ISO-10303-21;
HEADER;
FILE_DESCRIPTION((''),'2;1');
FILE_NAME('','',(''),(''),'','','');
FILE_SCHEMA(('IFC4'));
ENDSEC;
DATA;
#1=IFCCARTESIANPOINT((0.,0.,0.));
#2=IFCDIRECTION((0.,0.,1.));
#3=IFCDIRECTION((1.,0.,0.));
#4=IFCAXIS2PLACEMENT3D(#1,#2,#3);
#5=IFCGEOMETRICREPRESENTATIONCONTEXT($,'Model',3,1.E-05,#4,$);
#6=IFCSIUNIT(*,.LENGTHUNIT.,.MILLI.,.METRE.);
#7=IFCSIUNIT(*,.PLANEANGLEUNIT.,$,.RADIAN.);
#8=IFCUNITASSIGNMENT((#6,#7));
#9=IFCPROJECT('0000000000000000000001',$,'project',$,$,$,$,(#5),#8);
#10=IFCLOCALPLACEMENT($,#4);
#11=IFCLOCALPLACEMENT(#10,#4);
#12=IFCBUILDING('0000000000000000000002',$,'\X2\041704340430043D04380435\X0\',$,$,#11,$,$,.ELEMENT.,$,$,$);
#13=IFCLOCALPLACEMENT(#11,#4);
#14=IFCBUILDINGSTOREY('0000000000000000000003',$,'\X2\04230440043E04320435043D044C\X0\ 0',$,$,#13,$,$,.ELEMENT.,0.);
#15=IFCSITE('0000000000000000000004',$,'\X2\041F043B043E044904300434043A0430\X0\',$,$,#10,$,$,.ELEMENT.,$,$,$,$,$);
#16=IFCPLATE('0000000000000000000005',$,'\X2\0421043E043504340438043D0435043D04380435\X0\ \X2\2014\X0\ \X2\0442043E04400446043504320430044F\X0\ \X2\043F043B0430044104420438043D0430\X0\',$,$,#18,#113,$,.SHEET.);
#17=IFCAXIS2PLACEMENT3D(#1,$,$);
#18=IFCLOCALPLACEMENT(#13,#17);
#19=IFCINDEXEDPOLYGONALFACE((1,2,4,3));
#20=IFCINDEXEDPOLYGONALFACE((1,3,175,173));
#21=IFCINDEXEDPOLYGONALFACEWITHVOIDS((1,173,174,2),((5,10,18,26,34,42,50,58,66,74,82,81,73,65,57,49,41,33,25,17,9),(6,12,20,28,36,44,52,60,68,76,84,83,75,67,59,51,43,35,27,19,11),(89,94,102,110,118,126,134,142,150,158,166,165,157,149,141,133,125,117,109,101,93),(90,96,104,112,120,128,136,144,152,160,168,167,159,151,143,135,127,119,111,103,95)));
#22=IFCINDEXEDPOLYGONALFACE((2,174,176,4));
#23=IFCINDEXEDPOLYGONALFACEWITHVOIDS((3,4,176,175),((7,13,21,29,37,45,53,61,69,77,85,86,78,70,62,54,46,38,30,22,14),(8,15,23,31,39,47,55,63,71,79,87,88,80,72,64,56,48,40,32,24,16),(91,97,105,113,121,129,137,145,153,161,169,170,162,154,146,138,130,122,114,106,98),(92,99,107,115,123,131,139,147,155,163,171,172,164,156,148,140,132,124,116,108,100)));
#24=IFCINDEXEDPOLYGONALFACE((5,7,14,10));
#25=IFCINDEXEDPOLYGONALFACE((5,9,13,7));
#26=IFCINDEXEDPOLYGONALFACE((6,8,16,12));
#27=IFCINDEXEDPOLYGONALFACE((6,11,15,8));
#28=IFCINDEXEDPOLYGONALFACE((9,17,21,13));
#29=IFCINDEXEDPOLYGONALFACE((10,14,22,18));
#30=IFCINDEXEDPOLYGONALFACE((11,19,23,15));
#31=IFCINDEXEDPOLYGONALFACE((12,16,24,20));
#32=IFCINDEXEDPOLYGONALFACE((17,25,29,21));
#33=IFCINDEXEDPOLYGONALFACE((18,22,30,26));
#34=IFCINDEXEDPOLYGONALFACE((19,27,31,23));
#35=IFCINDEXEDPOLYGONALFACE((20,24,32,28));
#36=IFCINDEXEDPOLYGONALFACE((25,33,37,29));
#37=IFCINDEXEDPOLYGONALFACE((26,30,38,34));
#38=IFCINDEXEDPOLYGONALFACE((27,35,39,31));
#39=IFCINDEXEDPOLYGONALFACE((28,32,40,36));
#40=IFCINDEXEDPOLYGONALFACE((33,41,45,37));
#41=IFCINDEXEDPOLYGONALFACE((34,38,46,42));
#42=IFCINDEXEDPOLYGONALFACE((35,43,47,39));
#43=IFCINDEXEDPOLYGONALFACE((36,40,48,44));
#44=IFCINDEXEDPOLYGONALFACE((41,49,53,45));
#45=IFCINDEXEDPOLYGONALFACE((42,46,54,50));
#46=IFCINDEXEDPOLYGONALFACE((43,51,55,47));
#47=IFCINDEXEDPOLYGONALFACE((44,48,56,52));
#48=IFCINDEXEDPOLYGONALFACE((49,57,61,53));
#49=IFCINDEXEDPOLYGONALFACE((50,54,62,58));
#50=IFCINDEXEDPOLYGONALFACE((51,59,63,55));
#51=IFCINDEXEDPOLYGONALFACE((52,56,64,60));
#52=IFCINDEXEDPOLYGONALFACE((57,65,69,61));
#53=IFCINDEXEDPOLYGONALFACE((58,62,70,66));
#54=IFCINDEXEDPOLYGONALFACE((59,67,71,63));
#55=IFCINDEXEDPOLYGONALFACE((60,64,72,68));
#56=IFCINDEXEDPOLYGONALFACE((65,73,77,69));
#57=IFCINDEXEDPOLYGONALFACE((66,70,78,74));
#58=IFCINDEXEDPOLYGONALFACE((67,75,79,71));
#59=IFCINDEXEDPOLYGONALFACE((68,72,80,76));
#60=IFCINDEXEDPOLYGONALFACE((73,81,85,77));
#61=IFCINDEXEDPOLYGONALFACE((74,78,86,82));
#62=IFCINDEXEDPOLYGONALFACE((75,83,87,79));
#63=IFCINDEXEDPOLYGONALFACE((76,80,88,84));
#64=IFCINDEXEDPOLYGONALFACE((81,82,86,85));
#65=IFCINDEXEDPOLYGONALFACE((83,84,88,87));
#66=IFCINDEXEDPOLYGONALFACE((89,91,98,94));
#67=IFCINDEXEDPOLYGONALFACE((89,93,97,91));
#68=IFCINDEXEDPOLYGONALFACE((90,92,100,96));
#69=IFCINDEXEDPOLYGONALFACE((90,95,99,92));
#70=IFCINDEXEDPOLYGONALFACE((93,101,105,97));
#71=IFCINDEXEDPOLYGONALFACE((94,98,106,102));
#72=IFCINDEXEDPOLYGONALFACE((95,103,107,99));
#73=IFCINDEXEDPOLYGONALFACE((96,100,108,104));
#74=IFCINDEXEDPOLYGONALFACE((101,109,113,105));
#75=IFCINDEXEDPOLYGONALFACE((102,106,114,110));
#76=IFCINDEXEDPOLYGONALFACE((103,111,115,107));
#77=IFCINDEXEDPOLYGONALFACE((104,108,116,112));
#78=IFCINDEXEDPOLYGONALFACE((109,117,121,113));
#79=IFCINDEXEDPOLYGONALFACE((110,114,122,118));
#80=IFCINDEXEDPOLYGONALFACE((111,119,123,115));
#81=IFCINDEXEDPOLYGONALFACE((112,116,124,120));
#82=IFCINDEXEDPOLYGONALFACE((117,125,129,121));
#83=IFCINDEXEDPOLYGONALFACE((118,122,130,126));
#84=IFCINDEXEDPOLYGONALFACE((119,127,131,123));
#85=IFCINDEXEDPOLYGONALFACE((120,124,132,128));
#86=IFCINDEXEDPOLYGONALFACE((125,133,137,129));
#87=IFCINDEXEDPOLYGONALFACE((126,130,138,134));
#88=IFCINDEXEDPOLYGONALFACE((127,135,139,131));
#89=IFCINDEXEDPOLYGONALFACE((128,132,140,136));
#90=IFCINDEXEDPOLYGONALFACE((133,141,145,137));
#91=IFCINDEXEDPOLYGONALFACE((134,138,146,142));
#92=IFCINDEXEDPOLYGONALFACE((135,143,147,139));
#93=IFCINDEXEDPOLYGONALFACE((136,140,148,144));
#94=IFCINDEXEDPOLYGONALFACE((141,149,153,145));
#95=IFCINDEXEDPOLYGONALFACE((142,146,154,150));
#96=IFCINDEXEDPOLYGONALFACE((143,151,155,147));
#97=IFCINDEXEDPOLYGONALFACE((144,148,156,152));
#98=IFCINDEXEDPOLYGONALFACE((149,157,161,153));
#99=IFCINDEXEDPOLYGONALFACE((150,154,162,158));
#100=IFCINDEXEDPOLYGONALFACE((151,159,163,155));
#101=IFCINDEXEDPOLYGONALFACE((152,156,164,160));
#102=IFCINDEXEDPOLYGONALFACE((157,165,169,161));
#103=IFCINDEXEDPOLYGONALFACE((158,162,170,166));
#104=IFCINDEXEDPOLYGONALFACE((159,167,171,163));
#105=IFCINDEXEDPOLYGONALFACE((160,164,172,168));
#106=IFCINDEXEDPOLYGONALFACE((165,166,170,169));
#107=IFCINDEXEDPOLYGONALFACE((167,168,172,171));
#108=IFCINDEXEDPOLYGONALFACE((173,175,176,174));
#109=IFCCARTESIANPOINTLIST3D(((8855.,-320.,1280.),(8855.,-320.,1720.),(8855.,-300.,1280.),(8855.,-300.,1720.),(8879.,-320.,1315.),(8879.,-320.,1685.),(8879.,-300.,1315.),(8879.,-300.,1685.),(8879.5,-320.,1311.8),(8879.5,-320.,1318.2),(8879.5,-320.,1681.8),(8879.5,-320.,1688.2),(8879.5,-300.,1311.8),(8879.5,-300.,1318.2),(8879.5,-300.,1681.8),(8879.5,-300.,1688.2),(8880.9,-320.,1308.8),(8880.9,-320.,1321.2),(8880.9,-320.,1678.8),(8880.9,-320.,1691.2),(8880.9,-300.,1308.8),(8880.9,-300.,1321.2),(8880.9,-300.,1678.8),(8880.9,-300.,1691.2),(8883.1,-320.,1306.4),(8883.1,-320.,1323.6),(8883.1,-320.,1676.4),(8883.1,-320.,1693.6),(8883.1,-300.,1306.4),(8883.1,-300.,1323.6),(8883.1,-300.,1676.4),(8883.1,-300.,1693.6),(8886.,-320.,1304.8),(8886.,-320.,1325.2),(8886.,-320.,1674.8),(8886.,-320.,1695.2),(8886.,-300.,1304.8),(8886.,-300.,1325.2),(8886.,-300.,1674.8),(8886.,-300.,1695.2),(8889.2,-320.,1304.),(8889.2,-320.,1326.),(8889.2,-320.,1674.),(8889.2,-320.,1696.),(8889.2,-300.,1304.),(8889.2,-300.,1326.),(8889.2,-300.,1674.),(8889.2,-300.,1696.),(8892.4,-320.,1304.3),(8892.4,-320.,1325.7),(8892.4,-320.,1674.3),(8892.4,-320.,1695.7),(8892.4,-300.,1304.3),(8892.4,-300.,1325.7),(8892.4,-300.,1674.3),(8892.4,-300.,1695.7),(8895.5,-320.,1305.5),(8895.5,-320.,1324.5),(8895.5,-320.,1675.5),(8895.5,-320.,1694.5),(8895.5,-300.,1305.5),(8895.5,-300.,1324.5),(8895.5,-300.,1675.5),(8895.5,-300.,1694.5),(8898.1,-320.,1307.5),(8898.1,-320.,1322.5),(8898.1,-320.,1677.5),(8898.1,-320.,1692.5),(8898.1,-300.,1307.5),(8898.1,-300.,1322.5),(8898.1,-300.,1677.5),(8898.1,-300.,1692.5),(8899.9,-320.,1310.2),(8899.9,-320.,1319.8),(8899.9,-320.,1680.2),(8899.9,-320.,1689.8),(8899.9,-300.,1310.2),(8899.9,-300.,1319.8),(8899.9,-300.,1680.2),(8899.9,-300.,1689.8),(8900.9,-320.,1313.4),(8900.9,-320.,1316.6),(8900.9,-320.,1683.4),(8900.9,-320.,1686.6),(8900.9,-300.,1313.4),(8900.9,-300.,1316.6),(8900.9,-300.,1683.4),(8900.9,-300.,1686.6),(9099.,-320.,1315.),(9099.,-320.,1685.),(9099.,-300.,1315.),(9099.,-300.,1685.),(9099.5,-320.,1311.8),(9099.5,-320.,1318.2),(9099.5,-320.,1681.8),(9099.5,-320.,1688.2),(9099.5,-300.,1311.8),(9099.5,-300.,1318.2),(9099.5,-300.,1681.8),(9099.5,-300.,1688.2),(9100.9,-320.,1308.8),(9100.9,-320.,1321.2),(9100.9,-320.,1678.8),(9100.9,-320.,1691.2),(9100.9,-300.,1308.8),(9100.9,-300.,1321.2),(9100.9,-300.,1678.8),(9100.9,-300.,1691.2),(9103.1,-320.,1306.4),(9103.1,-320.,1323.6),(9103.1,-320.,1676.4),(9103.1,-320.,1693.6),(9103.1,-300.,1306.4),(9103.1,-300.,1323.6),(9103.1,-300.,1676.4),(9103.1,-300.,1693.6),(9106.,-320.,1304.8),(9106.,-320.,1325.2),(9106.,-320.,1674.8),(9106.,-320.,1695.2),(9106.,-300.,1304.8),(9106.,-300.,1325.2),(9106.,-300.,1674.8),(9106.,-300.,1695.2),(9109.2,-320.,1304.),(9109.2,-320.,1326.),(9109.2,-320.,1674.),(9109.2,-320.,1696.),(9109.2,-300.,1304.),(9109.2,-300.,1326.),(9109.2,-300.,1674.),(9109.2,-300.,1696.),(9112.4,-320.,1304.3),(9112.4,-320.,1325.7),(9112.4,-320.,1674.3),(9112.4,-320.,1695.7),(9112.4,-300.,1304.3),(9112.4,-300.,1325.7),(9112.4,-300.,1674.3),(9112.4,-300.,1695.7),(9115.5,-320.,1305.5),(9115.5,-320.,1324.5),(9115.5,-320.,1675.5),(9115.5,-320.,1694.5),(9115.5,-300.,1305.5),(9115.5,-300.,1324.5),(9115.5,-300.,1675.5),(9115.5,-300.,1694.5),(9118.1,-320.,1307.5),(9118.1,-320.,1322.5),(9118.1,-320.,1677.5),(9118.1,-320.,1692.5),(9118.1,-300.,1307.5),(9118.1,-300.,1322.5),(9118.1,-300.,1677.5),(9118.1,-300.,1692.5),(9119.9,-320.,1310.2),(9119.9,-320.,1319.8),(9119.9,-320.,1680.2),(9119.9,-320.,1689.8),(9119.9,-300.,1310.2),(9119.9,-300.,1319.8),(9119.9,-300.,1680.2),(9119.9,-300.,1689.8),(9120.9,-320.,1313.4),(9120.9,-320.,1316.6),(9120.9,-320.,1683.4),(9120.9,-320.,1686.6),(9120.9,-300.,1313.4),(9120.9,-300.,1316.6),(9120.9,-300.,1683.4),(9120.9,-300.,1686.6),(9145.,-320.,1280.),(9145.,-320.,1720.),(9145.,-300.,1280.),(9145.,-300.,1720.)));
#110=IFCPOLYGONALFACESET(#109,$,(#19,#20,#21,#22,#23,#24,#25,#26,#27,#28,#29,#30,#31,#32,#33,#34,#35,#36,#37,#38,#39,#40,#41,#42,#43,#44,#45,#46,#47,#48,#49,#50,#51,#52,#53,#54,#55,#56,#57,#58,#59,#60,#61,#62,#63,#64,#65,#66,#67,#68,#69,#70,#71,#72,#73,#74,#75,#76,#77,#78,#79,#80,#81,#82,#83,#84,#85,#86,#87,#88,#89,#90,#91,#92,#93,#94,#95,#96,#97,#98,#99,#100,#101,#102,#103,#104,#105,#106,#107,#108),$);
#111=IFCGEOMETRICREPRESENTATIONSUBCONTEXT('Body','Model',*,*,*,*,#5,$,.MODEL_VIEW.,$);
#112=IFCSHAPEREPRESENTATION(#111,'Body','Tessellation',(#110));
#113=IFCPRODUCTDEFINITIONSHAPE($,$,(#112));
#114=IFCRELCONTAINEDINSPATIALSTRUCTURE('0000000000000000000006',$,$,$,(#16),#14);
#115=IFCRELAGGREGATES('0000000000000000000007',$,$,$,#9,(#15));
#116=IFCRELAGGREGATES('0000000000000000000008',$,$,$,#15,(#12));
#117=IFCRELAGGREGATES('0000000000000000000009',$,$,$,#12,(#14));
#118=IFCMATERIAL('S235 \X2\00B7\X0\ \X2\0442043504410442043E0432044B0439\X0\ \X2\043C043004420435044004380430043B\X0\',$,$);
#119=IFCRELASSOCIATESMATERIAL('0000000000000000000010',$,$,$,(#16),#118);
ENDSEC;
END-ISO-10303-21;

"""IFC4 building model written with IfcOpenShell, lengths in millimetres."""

from ifc_helpers import new_model, si_unit, frame, origin_with_axes, place, context, subcontext, project, spatial, polyline, circle, outline, extrude, material, element, save


model = new_model("IFC4")

# Units and contexts
model_context = context("Model", 3, precision=1e-05, world=origin_with_axes())
body_context = subcontext(model_context, "Body", "Model", "MODEL_VIEW")
ifc_project = project(units=[si_unit("LENGTHUNIT", "METRE", prefix="MILLI"), si_unit("PLANEANGLEUNIT", "RADIAN")], contexts=[model_context])

# Site, building, storey
site_placement = place(None, origin_with_axes())
site = spatial("IfcSite", under=ifc_project, at=site_placement, Name="Площадка", CompositionType="ELEMENT")
building_placement = place(site_placement, origin_with_axes())
building = spatial("IfcBuilding", under=site, at=building_placement, Name="Здание", CompositionType="ELEMENT")
storey_placement = place(building_placement, origin_with_axes())
storey = spatial("IfcBuildingStorey", under=building, at=storey_placement, Name="Уровень 0", CompositionType="ELEMENT", Elevation=0.0)

# Shared definitions
ifc_material = material(Name="S235 · тестовый материал")

# Plate, openings
plate_placement = place(storey_placement, frame((9145.0, -320.0, 1280.0), z_axis=(0.0, 1.0, 0.0), x_axis=(-1.0, 0.0, 0.0)))
plate = element("IfcPlate", 1, at=plate_placement, inside=storey, material=ifc_material, Name="Соединение — торцевая пластина", PredefinedType="SHEET", context=body_context, shape_type="SweptSolid", body=[
    extrude(outline(polyline([(0.0, 0.0), (290.0, 0.0), (290.0, 440.0), (0.0, 440.0), (0.0, 0.0)])), origin_with_axes(), (0.0, 0.0, 1.0), 20.0),
])
opening_1_placement = place(plate_placement, frame((35.0, 35.0, -1.0), z_axis=(0.0, 0.0, 1.0), x_axis=(1.0, 0.0, 0.0)))
element("IfcOpeningElement", 2, at=opening_1_placement, cuts=plate, PredefinedType="OPENING", context=body_context, shape_type="SweptSolid", body=[
    extrude(circle(Radius=11.0), origin_with_axes(), (0.0, 0.0, 1.0), 42.0),
])
opening_2_placement = place(plate_placement, frame((35.0, 405.0, -1.0), z_axis=(0.0, 0.0, 1.0), x_axis=(1.0, 0.0, 0.0)))
element("IfcOpeningElement", 3, at=opening_2_placement, cuts=plate, PredefinedType="OPENING", context=body_context, shape_type="SweptSolid", body=[
    extrude(circle(Radius=11.0), origin_with_axes(), (0.0, 0.0, 1.0), 42.0),
])
opening_3_placement = place(plate_placement, frame((255.0, 35.0, -1.0), z_axis=(0.0, 0.0, 1.0), x_axis=(1.0, 0.0, 0.0)))
element("IfcOpeningElement", 4, at=opening_3_placement, cuts=plate, PredefinedType="OPENING", context=body_context, shape_type="SweptSolid", body=[
    extrude(circle(Radius=11.0), origin_with_axes(), (0.0, 0.0, 1.0), 42.0),
])
opening_4_placement = place(plate_placement, frame((255.0, 405.0, -1.0), z_axis=(0.0, 0.0, 1.0), x_axis=(1.0, 0.0, 0.0)))
element("IfcOpeningElement", 5, at=opening_4_placement, cuts=plate, PredefinedType="OPENING", context=body_context, shape_type="SweptSolid", body=[
    extrude(circle(Radius=11.0), origin_with_axes(), (0.0, 0.0, 1.0), 42.0),
])

save(model, "model.ifc")
